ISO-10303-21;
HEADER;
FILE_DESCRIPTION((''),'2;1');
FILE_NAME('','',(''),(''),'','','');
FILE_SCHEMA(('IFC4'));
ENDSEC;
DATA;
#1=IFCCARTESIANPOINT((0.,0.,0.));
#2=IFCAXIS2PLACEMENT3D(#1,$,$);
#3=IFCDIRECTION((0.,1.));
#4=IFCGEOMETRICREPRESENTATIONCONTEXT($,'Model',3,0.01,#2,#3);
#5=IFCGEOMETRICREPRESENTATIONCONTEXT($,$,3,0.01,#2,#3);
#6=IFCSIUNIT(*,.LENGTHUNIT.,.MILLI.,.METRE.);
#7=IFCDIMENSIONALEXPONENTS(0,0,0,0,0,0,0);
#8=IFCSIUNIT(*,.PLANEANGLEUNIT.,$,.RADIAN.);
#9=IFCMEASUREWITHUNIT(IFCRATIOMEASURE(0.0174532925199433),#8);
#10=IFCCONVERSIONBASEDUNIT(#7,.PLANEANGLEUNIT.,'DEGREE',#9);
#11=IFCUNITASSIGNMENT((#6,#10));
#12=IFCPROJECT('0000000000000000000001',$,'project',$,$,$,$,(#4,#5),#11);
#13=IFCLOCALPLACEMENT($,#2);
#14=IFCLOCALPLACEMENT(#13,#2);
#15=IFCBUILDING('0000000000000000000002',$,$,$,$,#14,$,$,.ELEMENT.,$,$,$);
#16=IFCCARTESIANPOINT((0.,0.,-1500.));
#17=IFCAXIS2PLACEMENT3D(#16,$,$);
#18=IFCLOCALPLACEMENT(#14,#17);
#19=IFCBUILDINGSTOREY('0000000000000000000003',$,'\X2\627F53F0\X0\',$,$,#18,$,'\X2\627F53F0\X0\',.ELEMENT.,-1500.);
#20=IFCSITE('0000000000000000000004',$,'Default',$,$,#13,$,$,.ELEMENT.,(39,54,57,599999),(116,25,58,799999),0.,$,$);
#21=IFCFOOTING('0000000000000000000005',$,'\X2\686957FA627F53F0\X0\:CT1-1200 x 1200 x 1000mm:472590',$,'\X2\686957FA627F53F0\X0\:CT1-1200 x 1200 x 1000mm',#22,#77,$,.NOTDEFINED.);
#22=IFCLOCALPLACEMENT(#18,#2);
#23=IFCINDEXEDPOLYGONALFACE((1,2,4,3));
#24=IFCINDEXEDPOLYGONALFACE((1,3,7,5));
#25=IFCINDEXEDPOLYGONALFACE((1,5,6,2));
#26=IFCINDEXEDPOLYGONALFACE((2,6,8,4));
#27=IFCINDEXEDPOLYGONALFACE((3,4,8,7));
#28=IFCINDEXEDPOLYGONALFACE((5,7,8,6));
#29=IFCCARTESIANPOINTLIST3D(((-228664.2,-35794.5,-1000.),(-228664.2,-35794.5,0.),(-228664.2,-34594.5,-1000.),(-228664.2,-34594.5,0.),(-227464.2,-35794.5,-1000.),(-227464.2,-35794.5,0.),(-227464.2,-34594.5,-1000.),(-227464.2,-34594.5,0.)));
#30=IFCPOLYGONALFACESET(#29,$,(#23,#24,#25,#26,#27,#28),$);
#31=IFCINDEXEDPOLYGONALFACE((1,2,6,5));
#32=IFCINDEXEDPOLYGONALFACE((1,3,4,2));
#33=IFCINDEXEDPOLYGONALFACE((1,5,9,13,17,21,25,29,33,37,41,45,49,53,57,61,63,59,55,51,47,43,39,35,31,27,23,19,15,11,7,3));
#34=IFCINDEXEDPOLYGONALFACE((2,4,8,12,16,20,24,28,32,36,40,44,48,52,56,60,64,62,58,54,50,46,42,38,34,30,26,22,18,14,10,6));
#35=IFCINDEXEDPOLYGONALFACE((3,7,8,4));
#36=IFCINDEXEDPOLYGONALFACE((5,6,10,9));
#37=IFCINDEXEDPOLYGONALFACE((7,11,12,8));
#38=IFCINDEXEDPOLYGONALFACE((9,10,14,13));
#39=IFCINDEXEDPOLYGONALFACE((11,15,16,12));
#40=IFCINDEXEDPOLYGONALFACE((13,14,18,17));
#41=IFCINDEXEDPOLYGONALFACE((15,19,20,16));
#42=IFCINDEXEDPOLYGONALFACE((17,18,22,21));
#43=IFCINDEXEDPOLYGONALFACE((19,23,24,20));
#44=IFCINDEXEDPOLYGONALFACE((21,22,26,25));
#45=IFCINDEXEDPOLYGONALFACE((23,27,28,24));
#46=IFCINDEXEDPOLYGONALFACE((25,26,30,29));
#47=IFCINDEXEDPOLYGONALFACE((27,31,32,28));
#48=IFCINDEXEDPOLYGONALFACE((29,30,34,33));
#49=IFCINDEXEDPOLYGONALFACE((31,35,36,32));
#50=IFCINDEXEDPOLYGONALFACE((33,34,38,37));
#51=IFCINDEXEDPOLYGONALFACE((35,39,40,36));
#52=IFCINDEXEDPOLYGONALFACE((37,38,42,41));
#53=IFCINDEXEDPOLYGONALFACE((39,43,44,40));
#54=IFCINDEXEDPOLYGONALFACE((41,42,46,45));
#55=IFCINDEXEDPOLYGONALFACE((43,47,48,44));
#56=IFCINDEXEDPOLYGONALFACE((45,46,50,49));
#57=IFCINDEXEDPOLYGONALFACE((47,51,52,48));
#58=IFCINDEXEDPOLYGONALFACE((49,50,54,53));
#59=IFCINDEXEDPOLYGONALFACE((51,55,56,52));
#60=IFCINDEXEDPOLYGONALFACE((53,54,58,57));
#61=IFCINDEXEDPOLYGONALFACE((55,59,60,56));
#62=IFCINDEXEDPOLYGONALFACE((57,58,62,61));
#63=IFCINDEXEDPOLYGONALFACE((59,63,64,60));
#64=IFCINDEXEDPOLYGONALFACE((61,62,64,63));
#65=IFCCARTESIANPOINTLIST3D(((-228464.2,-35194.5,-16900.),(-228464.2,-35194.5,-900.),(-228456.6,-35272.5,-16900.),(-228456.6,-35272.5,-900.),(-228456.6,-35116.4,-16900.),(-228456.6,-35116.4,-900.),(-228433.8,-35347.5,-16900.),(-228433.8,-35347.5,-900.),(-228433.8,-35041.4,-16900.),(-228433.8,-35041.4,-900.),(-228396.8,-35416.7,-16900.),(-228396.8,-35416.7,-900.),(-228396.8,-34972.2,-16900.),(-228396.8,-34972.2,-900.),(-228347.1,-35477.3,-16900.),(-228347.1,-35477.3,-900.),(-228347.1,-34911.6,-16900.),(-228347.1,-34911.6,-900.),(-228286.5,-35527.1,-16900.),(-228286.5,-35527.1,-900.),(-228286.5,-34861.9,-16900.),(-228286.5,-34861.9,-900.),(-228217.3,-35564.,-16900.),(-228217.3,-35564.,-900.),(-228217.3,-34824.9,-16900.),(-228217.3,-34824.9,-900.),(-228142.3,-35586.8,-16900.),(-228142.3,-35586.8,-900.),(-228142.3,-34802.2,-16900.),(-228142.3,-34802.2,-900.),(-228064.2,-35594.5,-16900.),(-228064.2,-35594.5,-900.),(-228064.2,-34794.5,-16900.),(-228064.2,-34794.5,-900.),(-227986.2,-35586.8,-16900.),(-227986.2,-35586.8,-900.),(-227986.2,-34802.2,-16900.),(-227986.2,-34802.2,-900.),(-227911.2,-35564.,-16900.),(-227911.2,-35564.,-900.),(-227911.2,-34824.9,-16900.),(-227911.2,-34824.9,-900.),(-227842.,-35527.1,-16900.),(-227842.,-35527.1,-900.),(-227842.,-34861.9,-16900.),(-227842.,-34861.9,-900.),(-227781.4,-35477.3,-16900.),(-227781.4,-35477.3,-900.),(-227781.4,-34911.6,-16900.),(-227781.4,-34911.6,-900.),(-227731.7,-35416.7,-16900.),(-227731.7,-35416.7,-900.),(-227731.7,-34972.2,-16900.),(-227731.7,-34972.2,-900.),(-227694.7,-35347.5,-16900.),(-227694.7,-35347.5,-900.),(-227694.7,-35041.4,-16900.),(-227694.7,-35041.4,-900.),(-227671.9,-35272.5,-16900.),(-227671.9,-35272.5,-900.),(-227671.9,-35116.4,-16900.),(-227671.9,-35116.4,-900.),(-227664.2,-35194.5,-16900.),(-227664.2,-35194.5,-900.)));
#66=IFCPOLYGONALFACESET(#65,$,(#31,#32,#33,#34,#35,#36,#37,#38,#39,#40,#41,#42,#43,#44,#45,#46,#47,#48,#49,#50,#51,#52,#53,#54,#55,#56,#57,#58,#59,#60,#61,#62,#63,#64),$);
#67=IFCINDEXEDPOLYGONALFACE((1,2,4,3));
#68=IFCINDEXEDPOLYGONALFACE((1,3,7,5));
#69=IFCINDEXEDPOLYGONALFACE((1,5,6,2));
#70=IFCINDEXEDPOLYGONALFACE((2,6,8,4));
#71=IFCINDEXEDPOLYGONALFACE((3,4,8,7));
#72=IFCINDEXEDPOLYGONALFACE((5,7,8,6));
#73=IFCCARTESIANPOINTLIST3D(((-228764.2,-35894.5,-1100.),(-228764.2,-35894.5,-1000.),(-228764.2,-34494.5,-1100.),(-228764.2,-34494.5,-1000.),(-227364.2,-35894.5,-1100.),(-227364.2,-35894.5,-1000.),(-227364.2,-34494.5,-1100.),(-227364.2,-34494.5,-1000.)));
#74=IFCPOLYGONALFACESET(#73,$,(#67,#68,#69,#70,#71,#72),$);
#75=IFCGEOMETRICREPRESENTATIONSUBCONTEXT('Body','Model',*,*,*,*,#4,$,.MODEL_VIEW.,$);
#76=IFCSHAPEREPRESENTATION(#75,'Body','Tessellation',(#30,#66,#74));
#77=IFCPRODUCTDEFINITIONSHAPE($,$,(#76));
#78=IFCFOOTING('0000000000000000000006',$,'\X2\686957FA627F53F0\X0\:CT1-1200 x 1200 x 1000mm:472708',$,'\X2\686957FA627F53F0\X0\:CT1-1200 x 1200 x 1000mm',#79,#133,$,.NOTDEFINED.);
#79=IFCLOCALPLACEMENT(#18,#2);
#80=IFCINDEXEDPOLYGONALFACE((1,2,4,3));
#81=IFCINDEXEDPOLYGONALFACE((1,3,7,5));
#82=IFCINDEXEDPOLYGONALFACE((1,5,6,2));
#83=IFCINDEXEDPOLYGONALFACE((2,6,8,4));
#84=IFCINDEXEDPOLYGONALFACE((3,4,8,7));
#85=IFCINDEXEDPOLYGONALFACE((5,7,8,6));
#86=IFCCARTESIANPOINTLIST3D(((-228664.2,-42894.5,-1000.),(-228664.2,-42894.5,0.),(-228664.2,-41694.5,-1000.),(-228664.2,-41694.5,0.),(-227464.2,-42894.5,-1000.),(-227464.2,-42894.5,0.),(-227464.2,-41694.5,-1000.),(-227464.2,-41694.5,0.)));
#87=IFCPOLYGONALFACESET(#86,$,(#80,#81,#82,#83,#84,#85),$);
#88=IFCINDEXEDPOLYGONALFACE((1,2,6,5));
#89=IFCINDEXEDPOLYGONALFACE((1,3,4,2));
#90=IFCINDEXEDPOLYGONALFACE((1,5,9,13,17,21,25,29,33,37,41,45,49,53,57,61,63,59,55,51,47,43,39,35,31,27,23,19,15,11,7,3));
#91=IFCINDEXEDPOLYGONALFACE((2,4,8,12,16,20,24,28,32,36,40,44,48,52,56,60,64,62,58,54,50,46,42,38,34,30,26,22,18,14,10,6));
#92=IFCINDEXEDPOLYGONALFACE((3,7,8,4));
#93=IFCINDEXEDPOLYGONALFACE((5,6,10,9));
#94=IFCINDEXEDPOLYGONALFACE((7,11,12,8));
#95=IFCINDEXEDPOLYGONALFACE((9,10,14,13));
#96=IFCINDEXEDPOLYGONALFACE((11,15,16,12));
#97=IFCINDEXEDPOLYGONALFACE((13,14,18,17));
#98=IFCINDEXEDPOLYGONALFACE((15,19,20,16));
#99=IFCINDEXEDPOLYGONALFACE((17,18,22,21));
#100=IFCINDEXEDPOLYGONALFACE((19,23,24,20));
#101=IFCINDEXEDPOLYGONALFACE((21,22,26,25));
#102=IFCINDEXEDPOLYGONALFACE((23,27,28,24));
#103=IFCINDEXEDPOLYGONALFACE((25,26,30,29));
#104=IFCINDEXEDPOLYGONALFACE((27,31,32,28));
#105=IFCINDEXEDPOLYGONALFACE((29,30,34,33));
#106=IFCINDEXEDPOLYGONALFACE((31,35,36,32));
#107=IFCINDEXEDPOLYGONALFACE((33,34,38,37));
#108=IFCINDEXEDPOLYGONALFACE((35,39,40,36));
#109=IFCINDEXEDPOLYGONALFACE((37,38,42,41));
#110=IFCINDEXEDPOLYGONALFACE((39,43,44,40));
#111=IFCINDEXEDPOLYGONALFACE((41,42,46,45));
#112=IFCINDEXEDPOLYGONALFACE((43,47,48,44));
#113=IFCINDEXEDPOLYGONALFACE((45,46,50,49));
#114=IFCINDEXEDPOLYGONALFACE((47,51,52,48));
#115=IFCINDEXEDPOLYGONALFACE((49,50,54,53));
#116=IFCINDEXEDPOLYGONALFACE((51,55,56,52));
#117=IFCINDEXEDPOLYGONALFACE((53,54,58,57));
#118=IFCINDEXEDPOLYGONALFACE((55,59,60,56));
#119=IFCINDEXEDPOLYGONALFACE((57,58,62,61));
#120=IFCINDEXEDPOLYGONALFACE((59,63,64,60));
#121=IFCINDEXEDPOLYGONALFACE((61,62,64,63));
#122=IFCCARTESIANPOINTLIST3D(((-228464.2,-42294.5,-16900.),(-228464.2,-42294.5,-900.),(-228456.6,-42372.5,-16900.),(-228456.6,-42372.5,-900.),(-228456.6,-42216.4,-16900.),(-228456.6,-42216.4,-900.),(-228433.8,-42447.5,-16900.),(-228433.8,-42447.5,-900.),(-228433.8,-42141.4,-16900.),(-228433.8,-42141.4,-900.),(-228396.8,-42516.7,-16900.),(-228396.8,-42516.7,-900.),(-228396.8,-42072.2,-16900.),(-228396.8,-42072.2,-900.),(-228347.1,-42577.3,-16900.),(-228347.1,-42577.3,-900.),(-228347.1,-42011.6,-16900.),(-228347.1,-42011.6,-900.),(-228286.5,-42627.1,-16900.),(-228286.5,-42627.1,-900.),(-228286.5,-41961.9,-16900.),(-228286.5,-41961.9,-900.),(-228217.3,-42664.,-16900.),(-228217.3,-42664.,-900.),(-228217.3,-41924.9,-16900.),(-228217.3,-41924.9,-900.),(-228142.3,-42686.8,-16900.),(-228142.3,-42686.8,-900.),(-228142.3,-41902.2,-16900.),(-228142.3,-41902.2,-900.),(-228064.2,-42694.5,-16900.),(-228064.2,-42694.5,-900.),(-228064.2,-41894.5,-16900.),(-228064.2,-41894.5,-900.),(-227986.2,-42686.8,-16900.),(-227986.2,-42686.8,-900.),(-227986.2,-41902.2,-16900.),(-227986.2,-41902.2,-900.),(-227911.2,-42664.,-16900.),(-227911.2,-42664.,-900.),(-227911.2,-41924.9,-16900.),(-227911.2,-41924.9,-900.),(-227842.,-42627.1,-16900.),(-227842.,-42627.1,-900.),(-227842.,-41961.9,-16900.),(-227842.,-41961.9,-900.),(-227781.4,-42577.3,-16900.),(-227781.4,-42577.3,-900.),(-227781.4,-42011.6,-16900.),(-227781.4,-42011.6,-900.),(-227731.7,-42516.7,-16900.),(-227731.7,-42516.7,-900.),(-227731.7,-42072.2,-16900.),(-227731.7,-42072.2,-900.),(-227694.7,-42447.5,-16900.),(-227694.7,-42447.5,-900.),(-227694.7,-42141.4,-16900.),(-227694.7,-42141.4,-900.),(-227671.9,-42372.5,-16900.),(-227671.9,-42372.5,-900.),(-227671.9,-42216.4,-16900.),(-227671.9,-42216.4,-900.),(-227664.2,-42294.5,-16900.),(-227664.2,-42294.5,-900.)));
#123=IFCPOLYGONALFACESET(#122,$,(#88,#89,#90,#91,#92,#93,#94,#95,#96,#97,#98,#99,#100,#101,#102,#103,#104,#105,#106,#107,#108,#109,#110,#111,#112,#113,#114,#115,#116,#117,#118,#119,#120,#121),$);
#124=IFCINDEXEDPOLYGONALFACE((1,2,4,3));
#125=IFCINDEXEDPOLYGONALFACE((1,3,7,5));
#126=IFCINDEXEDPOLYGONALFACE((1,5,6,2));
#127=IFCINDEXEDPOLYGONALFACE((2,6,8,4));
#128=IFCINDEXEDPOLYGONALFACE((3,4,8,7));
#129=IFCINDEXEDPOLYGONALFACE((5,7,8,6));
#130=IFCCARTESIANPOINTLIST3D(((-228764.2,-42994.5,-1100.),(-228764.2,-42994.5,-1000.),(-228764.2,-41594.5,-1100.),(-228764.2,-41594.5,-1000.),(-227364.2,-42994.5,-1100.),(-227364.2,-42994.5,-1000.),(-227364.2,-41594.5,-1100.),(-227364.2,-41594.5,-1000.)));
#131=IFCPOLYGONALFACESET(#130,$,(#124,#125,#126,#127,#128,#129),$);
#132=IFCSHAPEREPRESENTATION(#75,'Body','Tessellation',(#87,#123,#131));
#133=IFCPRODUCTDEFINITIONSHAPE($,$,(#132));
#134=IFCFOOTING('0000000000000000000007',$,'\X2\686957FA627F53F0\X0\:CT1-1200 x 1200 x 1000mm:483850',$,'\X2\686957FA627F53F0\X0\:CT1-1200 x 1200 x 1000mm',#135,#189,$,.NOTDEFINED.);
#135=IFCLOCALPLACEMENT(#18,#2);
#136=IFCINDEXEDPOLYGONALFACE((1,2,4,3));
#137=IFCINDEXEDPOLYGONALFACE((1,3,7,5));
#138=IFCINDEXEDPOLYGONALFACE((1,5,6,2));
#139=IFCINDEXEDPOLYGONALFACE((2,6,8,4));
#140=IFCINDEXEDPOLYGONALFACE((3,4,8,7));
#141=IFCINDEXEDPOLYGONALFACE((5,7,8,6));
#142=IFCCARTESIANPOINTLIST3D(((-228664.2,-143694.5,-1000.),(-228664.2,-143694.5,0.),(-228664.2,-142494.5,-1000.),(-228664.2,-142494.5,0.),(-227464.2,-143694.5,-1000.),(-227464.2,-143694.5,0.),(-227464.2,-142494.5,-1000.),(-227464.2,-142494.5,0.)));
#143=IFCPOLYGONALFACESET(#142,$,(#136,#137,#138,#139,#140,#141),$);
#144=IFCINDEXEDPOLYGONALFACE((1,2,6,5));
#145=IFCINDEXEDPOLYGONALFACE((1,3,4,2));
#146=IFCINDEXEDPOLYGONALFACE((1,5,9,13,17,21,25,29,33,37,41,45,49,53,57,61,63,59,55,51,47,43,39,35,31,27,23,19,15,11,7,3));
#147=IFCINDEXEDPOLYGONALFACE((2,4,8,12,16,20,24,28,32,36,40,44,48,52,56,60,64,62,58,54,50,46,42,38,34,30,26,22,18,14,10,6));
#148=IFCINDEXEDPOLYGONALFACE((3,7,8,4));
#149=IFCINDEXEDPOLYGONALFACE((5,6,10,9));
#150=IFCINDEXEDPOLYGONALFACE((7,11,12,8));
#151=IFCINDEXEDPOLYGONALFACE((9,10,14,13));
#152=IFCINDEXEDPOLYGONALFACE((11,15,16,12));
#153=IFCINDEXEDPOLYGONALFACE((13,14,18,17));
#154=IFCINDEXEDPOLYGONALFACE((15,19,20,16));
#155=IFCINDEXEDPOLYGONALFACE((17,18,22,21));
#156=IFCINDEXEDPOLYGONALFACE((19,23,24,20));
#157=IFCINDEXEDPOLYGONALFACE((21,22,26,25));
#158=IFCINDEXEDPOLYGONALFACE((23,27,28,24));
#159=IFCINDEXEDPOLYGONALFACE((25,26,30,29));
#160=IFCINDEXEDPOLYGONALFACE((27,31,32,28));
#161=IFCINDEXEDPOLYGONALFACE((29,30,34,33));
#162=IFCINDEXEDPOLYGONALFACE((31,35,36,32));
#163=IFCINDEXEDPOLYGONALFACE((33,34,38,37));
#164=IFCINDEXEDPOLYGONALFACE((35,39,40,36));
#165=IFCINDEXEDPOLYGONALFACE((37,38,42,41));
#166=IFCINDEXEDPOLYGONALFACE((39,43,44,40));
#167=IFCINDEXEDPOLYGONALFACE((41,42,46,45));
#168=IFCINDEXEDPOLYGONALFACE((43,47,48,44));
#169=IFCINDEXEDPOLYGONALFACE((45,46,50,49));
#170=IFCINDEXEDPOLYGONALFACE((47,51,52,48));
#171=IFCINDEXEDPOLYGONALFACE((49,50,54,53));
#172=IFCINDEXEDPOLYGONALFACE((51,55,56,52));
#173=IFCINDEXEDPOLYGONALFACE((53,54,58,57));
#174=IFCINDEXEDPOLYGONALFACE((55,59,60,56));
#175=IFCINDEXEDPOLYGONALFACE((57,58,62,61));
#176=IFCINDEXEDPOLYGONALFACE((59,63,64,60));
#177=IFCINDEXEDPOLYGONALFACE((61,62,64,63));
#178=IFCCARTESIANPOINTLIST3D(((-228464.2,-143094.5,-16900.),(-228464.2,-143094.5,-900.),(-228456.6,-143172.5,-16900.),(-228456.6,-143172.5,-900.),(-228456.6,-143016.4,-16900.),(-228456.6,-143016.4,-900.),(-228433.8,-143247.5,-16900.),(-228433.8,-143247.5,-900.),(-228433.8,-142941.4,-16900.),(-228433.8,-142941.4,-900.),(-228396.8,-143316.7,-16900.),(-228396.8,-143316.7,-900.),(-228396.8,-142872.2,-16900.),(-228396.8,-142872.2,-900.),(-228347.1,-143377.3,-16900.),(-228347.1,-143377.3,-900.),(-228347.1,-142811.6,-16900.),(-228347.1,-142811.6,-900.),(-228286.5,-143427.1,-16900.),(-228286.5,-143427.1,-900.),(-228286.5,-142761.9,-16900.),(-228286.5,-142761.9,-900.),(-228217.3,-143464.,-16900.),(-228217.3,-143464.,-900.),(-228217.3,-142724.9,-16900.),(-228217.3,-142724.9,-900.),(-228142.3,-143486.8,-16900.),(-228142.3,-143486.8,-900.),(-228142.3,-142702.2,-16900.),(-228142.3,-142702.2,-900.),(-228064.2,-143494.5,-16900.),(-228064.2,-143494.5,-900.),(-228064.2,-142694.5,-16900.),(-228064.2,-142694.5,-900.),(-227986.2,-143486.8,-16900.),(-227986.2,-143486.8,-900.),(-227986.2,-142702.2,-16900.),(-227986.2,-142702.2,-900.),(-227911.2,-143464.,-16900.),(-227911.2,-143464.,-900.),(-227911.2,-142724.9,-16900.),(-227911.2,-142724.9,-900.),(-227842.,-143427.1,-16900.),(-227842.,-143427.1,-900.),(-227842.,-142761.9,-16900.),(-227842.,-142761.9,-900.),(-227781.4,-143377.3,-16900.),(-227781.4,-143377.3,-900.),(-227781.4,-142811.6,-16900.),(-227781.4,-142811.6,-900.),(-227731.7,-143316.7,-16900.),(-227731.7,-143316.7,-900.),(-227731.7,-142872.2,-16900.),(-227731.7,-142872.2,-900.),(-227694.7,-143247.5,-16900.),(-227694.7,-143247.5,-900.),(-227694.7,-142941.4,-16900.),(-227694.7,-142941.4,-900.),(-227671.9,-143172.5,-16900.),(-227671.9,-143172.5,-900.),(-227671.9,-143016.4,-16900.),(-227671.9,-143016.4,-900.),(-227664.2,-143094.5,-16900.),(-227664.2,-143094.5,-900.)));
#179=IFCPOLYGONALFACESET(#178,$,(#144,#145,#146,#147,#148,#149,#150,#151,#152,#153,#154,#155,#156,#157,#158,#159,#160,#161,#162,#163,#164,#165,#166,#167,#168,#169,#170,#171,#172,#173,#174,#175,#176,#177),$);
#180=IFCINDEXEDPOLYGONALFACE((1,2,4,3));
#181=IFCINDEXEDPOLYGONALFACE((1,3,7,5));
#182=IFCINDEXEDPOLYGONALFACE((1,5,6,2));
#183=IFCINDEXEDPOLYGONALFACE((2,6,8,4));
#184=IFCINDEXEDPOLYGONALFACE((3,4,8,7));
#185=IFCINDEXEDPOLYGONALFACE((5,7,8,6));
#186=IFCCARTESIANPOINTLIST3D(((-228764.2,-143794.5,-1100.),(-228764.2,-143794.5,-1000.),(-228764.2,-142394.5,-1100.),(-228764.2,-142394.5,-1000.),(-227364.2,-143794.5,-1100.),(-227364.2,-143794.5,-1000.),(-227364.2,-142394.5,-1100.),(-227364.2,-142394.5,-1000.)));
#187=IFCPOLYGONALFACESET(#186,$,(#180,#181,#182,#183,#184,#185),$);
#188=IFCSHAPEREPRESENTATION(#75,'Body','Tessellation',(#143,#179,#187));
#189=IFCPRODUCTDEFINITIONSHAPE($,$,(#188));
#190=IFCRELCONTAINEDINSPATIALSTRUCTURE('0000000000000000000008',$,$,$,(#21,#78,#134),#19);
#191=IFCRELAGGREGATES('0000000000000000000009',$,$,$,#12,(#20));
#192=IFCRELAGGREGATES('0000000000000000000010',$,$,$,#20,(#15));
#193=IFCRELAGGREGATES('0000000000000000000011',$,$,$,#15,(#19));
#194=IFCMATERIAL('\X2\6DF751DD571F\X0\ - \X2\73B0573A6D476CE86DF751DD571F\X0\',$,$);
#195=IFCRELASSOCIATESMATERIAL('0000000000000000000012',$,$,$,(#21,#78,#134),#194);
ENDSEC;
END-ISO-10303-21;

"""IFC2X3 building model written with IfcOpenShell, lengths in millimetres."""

from ifc_helpers import new_model, entity, si_unit, converted_unit, direction, frame, frame_2d, origin, origin_2d_with_axis, place, context, subcontext, project, spatial, rectangle, circle, extrude, material, element, save


model = new_model("IFC2X3")

# Units and contexts
model_context = context("Model", 3, precision=0.01, world=origin(), true_north=direction((0.0, 1.0)))
context_of_model = context(None, 3, precision=0.01, world=origin(), true_north=direction((0.0, 1.0)))
body_context = subcontext(model_context, "Body", "Model", "MODEL_VIEW")
ifc_project = project(units=[si_unit("LENGTHUNIT", "METRE", prefix="MILLI"), converted_unit("PLANEANGLEUNIT", "DEGREE", entity("IfcRatioMeasure", 0.0174532925199433), si_unit("PLANEANGLEUNIT", "RADIAN"), dimensions=[0, 0, 0, 0, 0, 0, 0])], contexts=[model_context, context_of_model])

# Site, building, storey
site_placement = place(None, origin())
site = spatial("IfcSite", under=ifc_project, at=site_placement, Name="Default", CompositionType="ELEMENT", RefLatitude=(39, 54, 57, 599999), RefLongitude=(116, 25, 58, 799999), RefElevation=0.0)
building_placement = place(site_placement, origin())
building = spatial("IfcBuilding", under=site, at=building_placement, CompositionType="ELEMENT")
storey_placement = place(building_placement, frame((0.0, 0.0, -1500.0)))
storey = spatial("IfcBuildingStorey", under=building, at=storey_placement, Name="承台", LongName="承台", CompositionType="ELEMENT", Elevation=-1500.0)

# Footings
ifc_material_1 = material(Name="混凝土 - 现场浇注混凝土")
footing_1_placement = place(storey_placement, frame((-228764.2, -35894.5, -16900.0)))
element("IfcFooting", 1, at=footing_1_placement, inside=storey, material=ifc_material_1, Name="桩基承台:CT1-1200 x 1200 x 1000mm:472590", ObjectType="桩基承台:CT1-1200 x 1200 x 1000mm", PredefinedType="NOTDEFINED", context=body_context, shape_type="SweptSolid", body=[
    extrude(rectangle(XDim=1200.0, YDim=1200.0, at=frame_2d((-200.0, 50.0), x_axis=(1.0, 0.0))), frame((500.0, 750.0, 15900.0), z_axis=(0.0, 0.0, 1.0), x_axis=(-1.0, 0.0, 0.0)), (0.0, 0.0, 1.0), 1000.0),
    extrude(circle(Radius=400.0, at=origin_2d_with_axis()), frame((700.0, 700.0, 0.0)), (0.0, 0.0, 1.0), 16000.0),
    extrude(rectangle(XDim=1400.0, YDim=1400.0, at=frame_2d((0.0, 0.0), x_axis=(1.0, 0.0))), frame((700.0, 700.0, 15800.0), z_axis=(0.0, 0.0, 1.0), x_axis=(0.0, 1.0, 0.0)), (0.0, 0.0, 1.0), 100.0),
])
footing_2_placement = place(storey_placement, frame((-228764.2, -42994.5, -16900.0)))
element("IfcFooting", 2, at=footing_2_placement, inside=storey, material=ifc_material_1, Name="桩基承台:CT1-1200 x 1200 x 1000mm:472708", ObjectType="桩基承台:CT1-1200 x 1200 x 1000mm", PredefinedType="NOTDEFINED", context=body_context, shape_type="SweptSolid", body=[
    extrude(rectangle(XDim=1200.0, YDim=1200.0, at=frame_2d((-200.0, 50.0), x_axis=(1.0, 0.0))), frame((500.0, 750.0, 15900.0), z_axis=(0.0, 0.0, 1.0), x_axis=(-1.0, 0.0, 0.0)), (0.0, 0.0, 1.0), 1000.0),
    extrude(circle(Radius=400.0, at=origin_2d_with_axis()), frame((700.0, 700.0, 0.0)), (0.0, 0.0, 1.0), 16000.0),
    extrude(rectangle(XDim=1400.0, YDim=1400.0, at=frame_2d((0.0, 0.0), x_axis=(1.0, 0.0))), frame((700.0, 700.0, 15800.0), z_axis=(0.0, 0.0, 1.0), x_axis=(0.0, 1.0, 0.0)), (0.0, 0.0, 1.0), 100.0),
])
footing_3_placement = place(storey_placement, frame((-228764.2, -143794.5, -16900.0)))
element("IfcFooting", 3, at=footing_3_placement, inside=storey, material=ifc_material_1, Name="桩基承台:CT1-1200 x 1200 x 1000mm:483850", ObjectType="桩基承台:CT1-1200 x 1200 x 1000mm", PredefinedType="NOTDEFINED", context=body_context, shape_type="SweptSolid", body=[
    extrude(rectangle(XDim=1200.0, YDim=1200.0, at=frame_2d((-200.0, -50.0), x_axis=(1.0, 0.0))), frame((500.0, 650.0, 15900.0), z_axis=(0.0, 0.0, 1.0), x_axis=(-1.0, 0.0, 0.0)), (0.0, 0.0, 1.0), 1000.0),
    extrude(circle(Radius=400.0, at=origin_2d_with_axis()), frame((700.0, 700.0, 0.0)), (0.0, 0.0, 1.0), 16000.0),
    extrude(rectangle(XDim=1400.0, YDim=1400.0, at=frame_2d((0.0, 0.0), x_axis=(1.0, 0.0))), frame((700.0, 700.0, 15800.0), z_axis=(0.0, 0.0, 1.0), x_axis=(0.0, 1.0, 0.0)), (0.0, 0.0, 1.0), 100.0),
])

save(model, "model.ifc")
